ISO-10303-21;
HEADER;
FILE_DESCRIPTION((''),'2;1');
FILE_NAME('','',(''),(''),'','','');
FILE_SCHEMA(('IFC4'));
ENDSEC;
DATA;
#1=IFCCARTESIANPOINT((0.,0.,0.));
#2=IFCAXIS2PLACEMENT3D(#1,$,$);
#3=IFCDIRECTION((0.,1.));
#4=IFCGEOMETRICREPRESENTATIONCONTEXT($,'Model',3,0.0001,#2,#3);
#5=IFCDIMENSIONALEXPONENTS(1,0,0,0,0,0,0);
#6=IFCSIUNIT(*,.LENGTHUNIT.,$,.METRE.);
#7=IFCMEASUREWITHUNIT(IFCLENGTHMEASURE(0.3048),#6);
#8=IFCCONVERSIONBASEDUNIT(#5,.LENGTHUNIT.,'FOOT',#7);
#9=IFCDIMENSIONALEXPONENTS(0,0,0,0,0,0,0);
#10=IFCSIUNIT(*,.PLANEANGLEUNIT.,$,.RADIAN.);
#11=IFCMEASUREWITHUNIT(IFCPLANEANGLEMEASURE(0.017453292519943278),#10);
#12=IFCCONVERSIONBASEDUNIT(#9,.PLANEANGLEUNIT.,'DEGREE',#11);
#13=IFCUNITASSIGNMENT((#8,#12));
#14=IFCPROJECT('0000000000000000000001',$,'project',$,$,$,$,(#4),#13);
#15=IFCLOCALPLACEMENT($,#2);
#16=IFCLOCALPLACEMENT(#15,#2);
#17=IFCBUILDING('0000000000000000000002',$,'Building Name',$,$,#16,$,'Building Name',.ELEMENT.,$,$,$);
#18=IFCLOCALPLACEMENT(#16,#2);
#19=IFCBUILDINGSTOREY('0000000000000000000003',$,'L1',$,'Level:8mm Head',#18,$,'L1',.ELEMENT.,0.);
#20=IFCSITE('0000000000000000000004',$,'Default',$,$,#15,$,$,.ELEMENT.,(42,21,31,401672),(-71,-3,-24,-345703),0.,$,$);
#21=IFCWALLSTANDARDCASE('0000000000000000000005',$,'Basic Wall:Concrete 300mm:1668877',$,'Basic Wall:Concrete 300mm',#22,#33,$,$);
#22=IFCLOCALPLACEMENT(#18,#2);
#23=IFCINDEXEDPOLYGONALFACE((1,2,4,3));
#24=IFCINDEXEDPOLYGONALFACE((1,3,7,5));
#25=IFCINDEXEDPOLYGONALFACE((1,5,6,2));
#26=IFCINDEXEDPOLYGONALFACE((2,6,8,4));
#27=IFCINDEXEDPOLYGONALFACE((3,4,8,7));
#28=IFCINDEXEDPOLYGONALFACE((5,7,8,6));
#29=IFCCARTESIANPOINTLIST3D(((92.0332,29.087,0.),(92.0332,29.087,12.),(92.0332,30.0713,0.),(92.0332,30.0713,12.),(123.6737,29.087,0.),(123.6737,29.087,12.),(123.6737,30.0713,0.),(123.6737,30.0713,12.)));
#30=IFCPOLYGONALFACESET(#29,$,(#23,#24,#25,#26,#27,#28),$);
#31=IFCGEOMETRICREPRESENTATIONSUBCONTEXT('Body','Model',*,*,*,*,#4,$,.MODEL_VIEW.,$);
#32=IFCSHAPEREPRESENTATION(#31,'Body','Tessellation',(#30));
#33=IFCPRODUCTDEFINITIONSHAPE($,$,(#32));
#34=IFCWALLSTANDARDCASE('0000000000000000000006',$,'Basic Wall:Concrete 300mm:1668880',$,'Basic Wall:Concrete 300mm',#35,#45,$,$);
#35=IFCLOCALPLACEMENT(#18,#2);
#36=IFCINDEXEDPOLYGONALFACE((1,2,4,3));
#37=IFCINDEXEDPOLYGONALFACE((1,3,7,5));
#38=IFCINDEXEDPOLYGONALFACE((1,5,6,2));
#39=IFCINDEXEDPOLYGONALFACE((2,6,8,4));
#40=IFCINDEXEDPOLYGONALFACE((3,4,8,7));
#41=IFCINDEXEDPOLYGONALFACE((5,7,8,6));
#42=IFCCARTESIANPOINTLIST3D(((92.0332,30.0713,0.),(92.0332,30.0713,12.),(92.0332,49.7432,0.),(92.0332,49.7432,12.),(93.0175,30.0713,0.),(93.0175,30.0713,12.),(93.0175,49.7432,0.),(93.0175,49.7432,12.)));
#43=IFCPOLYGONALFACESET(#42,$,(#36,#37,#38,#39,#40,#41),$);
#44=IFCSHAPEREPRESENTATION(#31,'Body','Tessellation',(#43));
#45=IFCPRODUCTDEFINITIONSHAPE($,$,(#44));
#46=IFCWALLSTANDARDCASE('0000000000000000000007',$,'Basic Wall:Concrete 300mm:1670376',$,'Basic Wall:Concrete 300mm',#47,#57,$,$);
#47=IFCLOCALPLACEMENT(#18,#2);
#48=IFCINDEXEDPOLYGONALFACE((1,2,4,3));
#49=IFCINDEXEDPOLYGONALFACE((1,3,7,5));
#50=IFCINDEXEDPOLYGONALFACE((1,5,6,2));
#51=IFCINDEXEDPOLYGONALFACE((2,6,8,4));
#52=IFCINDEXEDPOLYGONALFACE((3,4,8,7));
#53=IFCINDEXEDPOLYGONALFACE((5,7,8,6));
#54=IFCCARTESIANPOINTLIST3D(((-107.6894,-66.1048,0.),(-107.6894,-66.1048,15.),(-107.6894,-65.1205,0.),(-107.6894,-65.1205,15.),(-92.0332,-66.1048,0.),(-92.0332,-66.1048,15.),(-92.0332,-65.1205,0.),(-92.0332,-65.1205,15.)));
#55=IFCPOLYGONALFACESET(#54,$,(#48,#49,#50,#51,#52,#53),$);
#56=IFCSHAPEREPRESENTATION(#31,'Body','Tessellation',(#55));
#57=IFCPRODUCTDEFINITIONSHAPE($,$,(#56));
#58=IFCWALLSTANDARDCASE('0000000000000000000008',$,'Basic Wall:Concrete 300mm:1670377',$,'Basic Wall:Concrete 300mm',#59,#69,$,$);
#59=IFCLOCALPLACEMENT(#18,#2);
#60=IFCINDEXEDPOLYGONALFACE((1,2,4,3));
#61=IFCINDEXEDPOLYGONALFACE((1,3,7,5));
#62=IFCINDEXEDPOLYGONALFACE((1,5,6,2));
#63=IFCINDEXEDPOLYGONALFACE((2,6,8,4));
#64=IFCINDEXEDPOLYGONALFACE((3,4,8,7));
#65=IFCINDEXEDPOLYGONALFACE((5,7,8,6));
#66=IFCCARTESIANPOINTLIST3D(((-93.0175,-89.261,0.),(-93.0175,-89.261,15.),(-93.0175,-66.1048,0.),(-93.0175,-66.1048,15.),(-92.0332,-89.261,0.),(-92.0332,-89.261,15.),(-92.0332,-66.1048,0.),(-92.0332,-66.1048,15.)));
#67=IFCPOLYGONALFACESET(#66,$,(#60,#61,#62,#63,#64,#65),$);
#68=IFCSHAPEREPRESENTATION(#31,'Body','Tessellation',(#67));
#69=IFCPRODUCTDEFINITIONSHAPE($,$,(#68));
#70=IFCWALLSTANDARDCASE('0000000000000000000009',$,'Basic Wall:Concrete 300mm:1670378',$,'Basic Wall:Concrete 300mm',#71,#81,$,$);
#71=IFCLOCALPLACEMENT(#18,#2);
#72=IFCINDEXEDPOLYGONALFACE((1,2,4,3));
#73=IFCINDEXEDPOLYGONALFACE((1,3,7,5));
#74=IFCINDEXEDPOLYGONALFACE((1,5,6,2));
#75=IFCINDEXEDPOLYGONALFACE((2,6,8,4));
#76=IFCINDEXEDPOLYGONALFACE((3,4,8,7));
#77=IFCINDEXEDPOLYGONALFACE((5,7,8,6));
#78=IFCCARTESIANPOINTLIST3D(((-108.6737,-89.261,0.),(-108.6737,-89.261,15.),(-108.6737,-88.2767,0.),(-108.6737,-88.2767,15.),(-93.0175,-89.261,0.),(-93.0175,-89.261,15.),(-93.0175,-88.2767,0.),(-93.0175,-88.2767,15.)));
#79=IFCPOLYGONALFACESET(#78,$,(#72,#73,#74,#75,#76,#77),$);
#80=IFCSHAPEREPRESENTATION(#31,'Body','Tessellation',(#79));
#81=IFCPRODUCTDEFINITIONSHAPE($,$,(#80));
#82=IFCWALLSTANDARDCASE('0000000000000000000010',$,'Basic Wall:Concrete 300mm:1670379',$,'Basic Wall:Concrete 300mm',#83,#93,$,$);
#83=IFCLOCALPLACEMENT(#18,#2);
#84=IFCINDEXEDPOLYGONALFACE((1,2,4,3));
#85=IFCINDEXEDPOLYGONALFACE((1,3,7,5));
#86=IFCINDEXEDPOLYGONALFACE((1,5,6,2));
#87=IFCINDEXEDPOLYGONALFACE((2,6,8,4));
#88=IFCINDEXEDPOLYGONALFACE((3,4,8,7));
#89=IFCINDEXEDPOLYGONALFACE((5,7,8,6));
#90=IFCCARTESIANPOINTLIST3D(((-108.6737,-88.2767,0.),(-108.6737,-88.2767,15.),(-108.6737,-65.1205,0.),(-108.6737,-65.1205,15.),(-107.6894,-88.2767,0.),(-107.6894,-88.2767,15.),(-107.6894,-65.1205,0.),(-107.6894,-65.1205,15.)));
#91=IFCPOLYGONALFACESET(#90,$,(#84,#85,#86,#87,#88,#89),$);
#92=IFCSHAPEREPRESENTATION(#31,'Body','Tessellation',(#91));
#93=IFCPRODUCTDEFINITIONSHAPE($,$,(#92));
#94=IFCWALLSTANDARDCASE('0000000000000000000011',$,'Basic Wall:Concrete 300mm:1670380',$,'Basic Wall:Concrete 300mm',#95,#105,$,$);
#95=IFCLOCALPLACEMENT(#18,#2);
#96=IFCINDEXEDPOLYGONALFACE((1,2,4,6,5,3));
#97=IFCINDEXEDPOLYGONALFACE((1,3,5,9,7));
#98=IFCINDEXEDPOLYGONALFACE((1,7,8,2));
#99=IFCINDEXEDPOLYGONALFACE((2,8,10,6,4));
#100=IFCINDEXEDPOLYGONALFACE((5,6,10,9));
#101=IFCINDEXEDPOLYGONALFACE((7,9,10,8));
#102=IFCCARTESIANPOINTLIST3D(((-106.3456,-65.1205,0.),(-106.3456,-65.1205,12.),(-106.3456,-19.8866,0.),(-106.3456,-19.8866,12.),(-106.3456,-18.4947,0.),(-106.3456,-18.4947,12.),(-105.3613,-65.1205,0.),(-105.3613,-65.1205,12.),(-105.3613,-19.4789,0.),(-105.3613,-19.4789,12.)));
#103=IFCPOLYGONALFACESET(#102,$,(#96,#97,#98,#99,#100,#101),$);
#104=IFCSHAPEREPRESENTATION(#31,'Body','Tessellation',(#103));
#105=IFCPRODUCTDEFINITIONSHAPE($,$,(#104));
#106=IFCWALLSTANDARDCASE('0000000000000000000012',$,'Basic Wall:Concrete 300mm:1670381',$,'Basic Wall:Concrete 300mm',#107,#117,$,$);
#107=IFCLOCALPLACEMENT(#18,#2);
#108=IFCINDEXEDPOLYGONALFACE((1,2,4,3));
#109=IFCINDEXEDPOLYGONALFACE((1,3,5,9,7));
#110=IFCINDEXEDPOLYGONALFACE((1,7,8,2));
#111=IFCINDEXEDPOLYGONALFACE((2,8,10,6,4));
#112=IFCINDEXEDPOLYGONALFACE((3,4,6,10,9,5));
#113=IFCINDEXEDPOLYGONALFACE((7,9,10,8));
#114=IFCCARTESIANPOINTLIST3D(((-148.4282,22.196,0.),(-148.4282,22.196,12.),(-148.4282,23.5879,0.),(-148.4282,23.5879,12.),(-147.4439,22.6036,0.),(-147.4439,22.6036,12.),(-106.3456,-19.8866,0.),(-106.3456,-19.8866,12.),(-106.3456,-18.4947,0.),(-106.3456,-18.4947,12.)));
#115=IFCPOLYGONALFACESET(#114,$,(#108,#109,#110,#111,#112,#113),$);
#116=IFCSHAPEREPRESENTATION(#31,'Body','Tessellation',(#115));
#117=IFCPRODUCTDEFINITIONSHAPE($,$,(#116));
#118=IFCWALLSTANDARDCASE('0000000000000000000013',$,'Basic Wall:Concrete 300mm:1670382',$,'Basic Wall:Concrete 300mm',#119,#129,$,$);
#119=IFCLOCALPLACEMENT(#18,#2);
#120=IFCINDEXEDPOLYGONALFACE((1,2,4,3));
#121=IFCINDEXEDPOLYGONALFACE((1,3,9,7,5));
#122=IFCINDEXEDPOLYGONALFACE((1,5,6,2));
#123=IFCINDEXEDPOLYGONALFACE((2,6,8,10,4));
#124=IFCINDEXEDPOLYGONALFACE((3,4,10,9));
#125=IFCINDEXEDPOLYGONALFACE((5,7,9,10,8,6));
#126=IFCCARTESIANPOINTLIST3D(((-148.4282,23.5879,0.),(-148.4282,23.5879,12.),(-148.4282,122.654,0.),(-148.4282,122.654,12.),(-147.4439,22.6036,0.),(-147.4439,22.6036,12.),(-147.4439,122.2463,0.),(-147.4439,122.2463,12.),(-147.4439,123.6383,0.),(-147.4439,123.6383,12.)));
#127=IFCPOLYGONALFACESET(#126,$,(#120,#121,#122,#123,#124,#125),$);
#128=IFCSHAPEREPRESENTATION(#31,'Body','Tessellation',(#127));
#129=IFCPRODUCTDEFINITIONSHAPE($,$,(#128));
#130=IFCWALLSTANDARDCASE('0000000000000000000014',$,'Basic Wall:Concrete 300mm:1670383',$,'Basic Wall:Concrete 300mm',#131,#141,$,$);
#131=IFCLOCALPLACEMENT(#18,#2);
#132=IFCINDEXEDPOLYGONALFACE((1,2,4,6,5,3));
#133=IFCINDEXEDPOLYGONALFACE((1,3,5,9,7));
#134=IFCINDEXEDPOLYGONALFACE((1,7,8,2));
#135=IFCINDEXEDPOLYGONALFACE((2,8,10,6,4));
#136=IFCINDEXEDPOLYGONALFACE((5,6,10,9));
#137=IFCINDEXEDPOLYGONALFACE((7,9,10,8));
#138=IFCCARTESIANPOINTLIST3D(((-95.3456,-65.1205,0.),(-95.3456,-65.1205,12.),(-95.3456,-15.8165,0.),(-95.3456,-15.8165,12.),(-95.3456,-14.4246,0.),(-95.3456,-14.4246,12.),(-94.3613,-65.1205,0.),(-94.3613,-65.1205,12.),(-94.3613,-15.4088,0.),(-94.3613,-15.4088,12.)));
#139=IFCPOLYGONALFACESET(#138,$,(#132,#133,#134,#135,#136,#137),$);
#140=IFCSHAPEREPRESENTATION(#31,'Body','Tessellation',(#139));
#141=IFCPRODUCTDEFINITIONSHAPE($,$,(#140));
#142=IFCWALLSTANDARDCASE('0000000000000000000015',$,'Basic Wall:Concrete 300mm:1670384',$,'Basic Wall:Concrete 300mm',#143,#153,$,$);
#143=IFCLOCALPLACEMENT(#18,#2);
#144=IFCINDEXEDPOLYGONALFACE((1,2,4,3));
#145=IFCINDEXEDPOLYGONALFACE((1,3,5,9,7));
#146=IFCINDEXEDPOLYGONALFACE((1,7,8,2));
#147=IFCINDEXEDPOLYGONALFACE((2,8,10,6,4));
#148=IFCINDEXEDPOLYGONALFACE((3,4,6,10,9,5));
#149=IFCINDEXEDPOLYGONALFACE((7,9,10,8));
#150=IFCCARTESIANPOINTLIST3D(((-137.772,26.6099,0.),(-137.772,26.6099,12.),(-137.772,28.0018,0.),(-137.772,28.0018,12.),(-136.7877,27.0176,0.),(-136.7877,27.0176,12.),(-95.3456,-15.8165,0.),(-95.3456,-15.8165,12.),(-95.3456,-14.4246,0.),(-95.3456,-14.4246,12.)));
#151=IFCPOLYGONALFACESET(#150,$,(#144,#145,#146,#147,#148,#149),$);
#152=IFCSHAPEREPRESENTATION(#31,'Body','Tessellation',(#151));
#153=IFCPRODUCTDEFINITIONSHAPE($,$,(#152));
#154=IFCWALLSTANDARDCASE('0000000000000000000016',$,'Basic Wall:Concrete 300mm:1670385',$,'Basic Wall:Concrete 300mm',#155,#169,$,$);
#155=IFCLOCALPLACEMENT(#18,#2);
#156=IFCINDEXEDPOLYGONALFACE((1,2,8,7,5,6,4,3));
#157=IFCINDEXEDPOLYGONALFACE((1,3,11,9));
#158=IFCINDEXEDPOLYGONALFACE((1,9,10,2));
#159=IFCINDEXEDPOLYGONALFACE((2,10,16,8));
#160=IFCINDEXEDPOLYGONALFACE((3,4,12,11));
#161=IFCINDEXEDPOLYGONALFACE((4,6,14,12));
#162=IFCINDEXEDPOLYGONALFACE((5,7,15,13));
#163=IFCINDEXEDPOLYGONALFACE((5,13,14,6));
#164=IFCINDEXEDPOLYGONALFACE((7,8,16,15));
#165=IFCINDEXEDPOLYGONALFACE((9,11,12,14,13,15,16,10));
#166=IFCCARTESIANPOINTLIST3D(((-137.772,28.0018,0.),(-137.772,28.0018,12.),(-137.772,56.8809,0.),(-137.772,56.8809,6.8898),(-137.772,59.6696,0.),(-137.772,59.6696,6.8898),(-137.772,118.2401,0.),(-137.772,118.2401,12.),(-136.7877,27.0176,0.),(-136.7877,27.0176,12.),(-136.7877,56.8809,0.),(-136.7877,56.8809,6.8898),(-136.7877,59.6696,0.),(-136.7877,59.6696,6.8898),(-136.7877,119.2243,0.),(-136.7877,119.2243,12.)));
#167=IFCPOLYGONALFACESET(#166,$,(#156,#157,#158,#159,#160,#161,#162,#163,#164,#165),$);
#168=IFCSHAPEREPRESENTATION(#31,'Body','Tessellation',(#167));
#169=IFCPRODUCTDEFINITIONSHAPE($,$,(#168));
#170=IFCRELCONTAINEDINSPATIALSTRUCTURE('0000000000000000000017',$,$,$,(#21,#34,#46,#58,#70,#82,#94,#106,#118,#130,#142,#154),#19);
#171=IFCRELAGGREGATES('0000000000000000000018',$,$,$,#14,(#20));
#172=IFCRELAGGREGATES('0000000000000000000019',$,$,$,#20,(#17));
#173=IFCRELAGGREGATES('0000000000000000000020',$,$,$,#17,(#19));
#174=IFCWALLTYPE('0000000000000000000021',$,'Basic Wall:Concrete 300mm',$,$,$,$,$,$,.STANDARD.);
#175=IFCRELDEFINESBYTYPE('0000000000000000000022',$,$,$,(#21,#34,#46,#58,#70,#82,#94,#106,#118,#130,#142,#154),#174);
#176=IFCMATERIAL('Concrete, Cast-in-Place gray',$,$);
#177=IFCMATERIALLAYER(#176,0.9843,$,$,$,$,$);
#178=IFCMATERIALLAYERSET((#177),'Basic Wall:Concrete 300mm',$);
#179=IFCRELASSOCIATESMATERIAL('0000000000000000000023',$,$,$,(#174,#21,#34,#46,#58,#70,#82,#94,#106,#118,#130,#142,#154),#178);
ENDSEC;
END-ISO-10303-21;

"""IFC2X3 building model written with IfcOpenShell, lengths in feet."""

from ifc_helpers import new_model, entity, si_unit, converted_unit, direction, frame, frame_2d, origin, place, context, subcontext, project, spatial, polyline, rectangle, outline, extrude, material, layer, layer_set, layer_usage, type_object, element, save


model = new_model("IFC2X3")

# Units and contexts
model_context = context("Model", 3, precision=0.0001, world=origin(), true_north=direction((0.0, 1.0)))
body_context = subcontext(model_context, "Body", "Model", "MODEL_VIEW")
ifc_project = project(units=[converted_unit("LENGTHUNIT", "FOOT", entity("IfcLengthMeasure", 0.3048), si_unit("LENGTHUNIT", "METRE"), dimensions=[1, 0, 0, 0, 0, 0, 0]), converted_unit("PLANEANGLEUNIT", "DEGREE", entity("IfcPlaneAngleMeasure", 0.017453292519943278), si_unit("PLANEANGLEUNIT", "RADIAN"), dimensions=[0, 0, 0, 0, 0, 0, 0])], contexts=[model_context])

# Site, building, storey
site_placement = place(None, origin())
site = spatial("IfcSite", under=ifc_project, at=site_placement, Name="Default", CompositionType="ELEMENT", RefLatitude=(42, 21, 31, 401672), RefLongitude=(-71, -3, -24, -345703), RefElevation=0.0)
building_placement = place(site_placement, origin())
building = spatial("IfcBuilding", under=site, at=building_placement, Name="Building Name", LongName="Building Name", CompositionType="ELEMENT")
storey_placement = place(building_placement, origin())
storey = spatial("IfcBuildingStorey", under=building, at=storey_placement, Name="L1", ObjectType="Level:8mm Head", LongName="L1", CompositionType="ELEMENT", Elevation=0.0)

# Shared definitions
ifc_material_1 = material(Name="Concrete, Cast-in-Place gray")
ifc_layer_1 = layer(ifc_material_1, 0.9843)
ifc_layer_set_1 = layer_set([ifc_layer_1], Name="Basic Wall:Concrete 300mm")
wall_type = type_object("IfcWallType", Name="Basic Wall:Concrete 300mm", PredefinedType="STANDARD", material=ifc_layer_set_1)

# Walls
ifc_layer_usage_1 = layer_usage(ifc_layer_set_1, "AXIS2", "NEGATIVE", 0.4921)
wall_1_placement = place(storey_placement, frame((123.6737, 29.5792, 0.0), z_axis=(0.0, 0.0, 1.0), x_axis=(-1.0, 0.0, 0.0)))
element("IfcWallStandardCase", 1, at=wall_1_placement, inside=storey, type_object=wall_type, material=ifc_layer_usage_1, Name="Basic Wall:Concrete 300mm:1668877", ObjectType="Basic Wall:Concrete 300mm", context=body_context, shape_type="SweptSolid", body=[
    extrude(rectangle(XDim=31.6404, YDim=0.9843, at=frame_2d((15.8202, 0.0), x_axis=(-1.0, 0.0))), origin(), (0.0, 0.0, 1.0), 12.0),
])
ifc_layer_usage_2 = layer_usage(ifc_layer_set_1, "AXIS2", "NEGATIVE", 0.4921)
wall_2_placement = place(storey_placement, frame((92.5254, 30.0713, 0.0), z_axis=(0.0, 0.0, 1.0), x_axis=(0.0, 1.0, 0.0)))
element("IfcWallStandardCase", 2, at=wall_2_placement, inside=storey, type_object=wall_type, material=ifc_layer_usage_2, Name="Basic Wall:Concrete 300mm:1668880", ObjectType="Basic Wall:Concrete 300mm", context=body_context, shape_type="SweptSolid", body=[
    extrude(rectangle(XDim=19.6719, YDim=0.9843, at=frame_2d((9.836, 0.0), x_axis=(-1.0, 0.0))), origin(), (0.0, 0.0, 1.0), 12.0),
])
ifc_layer_usage_3 = layer_usage(ifc_layer_set_1, "AXIS2", "POSITIVE", -0.4921)
wall_3_placement = place(storey_placement, frame((-92.0332, -65.6127, 0.0), z_axis=(0.0, 0.0, 1.0), x_axis=(-1.0, 0.0, 0.0)))
element("IfcWallStandardCase", 3, at=wall_3_placement, inside=storey, type_object=wall_type, material=ifc_layer_usage_3, Name="Basic Wall:Concrete 300mm:1670376", ObjectType="Basic Wall:Concrete 300mm", context=body_context, shape_type="SweptSolid", body=[
    extrude(rectangle(XDim=15.6562, YDim=0.9843, at=frame_2d((7.8281, 0.0), x_axis=(-1.0, 0.0))), origin(), (0.0, 0.0, 1.0), 15.0),
])
ifc_layer_usage_4 = layer_usage(ifc_layer_set_1, "AXIS2", "POSITIVE", -0.4921)
wall_4_placement = place(storey_placement, frame((-92.5254, -89.261, 0.0), z_axis=(0.0, 0.0, 1.0), x_axis=(0.0, 1.0, 0.0)))
element("IfcWallStandardCase", 4, at=wall_4_placement, inside=storey, type_object=wall_type, material=ifc_layer_usage_4, Name="Basic Wall:Concrete 300mm:1670377", ObjectType="Basic Wall:Concrete 300mm", context=body_context, shape_type="SweptSolid", body=[
    extrude(rectangle(XDim=23.1562, YDim=0.9843, at=frame_2d((11.5781, 0.0), x_axis=(-1.0, 0.0))), origin(), (0.0, 0.0, 1.0), 15.0),
])
ifc_layer_usage_5 = layer_usage(ifc_layer_set_1, "AXIS2", "NEGATIVE", 0.4921)
wall_5_placement = place(storey_placement, frame((-108.6737, -88.7688, 0.0)))
element("IfcWallStandardCase", 5, at=wall_5_placement, inside=storey, type_object=wall_type, material=ifc_layer_usage_5, Name="Basic Wall:Concrete 300mm:1670378", ObjectType="Basic Wall:Concrete 300mm", context=body_context, shape_type="SweptSolid", body=[
    extrude(rectangle(XDim=15.6562, YDim=0.9843, at=frame_2d((7.8281, 0.0), x_axis=(-1.0, 0.0))), origin(), (0.0, 0.0, 1.0), 15.0),
])
ifc_layer_usage_6 = layer_usage(ifc_layer_set_1, "AXIS2", "POSITIVE", -0.4921)
wall_6_placement = place(storey_placement, frame((-108.1815, -65.1205, 0.0), z_axis=(0.0, 0.0, 1.0), x_axis=(0.0, -1.0, 0.0)))
element("IfcWallStandardCase", 6, at=wall_6_placement, inside=storey, type_object=wall_type, material=ifc_layer_usage_6, Name="Basic Wall:Concrete 300mm:1670379", ObjectType="Basic Wall:Concrete 300mm", context=body_context, shape_type="SweptSolid", body=[
    extrude(rectangle(XDim=23.1562, YDim=0.9843, at=frame_2d((11.5781, 0.0), x_axis=(-1.0, 0.0))), origin(), (0.0, 0.0, 1.0), 15.0),
])
ifc_layer_usage_7 = layer_usage(ifc_layer_set_1, "AXIS2", "POSITIVE", -0.4921)
wall_7_placement = place(storey_placement, frame((-105.8535, -65.1205, 0.0), z_axis=(0.0, 0.0, 1.0), x_axis=(0.0, 1.0, 0.0)))
element("IfcWallStandardCase", 7, at=wall_7_placement, inside=storey, type_object=wall_type, material=ifc_layer_usage_7, Name="Basic Wall:Concrete 300mm:1670380", ObjectType="Basic Wall:Concrete 300mm", context=body_context, shape_type="SweptSolid", body=[
    extrude(outline(polyline([(45.6416, -0.4921), (46.6259, 0.4921), (45.2339, 0.4921), (0.0, 0.4921), (0.0, -0.4921), (45.6416, -0.4921)])), origin(), (0.0, 0.0, 1.0), 12.0),
])
ifc_layer_usage_8 = layer_usage(ifc_layer_set_1, "AXIS2", "POSITIVE", -0.4921)
wall_8_placement = place(storey_placement, frame((-105.9976, -19.5386, 0.0), z_axis=(0.0, 0.0, 1.0), x_axis=(-0.707107, 0.707107, 0.0)))
element("IfcWallStandardCase", 8, at=wall_8_placement, inside=storey, type_object=wall_type, material=ifc_layer_usage_8, Name="Basic Wall:Concrete 300mm:1670381", ObjectType="Basic Wall:Concrete 300mm", context=body_context, shape_type="SweptSolid", body=[
    extrude(outline(polyline([(60.498, -0.4921), (59.5137, 0.4921), (0.0, 0.4921), (0.9843, -0.4921), (59.1061, -0.4921), (60.498, -0.4921)])), origin(), (0.0, 0.0, 1.0), 12.0),
])
ifc_layer_usage_9 = layer_usage(ifc_layer_set_1, "AXIS2", "POSITIVE", -0.4921)
wall_9_placement = place(storey_placement, frame((-147.936, 22.6036, 0.0), z_axis=(0.0, 0.0, 1.0), x_axis=(0.0, 1.0, 0.0)))
element("IfcWallStandardCase", 9, at=wall_9_placement, inside=storey, type_object=wall_type, material=ifc_layer_usage_9, Name="Basic Wall:Concrete 300mm:1670382", ObjectType="Basic Wall:Concrete 300mm", context=body_context, shape_type="SweptSolid", body=[
    extrude(outline(polyline([(101.0346, -0.4921), (100.0504, 0.4921), (0.9843, 0.4921), (0.0, -0.4921), (99.6427, -0.4921), (101.0346, -0.4921)])), origin(), (0.0, 0.0, 1.0), 12.0),
])
ifc_layer_usage_10 = layer_usage(ifc_layer_set_1, "AXIS2", "POSITIVE", -0.4921)
wall_10_placement = place(storey_placement, frame((-94.8535, -65.1205, 0.0), z_axis=(0.0, 0.0, 1.0), x_axis=(0.0, 1.0, 0.0)))
element("IfcWallStandardCase", 10, at=wall_10_placement, inside=storey, type_object=wall_type, material=ifc_layer_usage_10, Name="Basic Wall:Concrete 300mm:1670383", ObjectType="Basic Wall:Concrete 300mm", context=body_context, shape_type="SweptSolid", body=[
    extrude(outline(polyline([(49.7117, -0.4921), (50.696, 0.4921), (49.304, 0.4921), (0.0, 0.4921), (0.0, -0.4921), (49.7117, -0.4921)])), origin(), (0.0, 0.0, 1.0), 12.0),
])
ifc_layer_usage_11 = layer_usage(ifc_layer_set_1, "AXIS2", "POSITIVE", -0.4921)
wall_11_placement = place(storey_placement, frame((-94.9976, -15.4685, 0.0), z_axis=(0.0, 0.0, 1.0), x_axis=(-0.707107, 0.707107, 0.0)))
element("IfcWallStandardCase", 11, at=wall_11_placement, inside=storey, type_object=wall_type, material=ifc_layer_usage_11, Name="Basic Wall:Concrete 300mm:1670384", ObjectType="Basic Wall:Concrete 300mm", context=body_context, shape_type="SweptSolid", body=[
    extrude(outline(polyline([(60.9843, -0.4921), (60.0, 0.4921), (0.0, 0.4921), (0.9843, -0.4921), (59.5923, -0.4921), (60.9843, -0.4921)])), origin(), (0.0, 0.0, 1.0), 12.0),
])

# Wall, opening
ifc_layer_usage_12 = layer_usage(ifc_layer_set_1, "AXIS2", "POSITIVE", -0.4921)
wall_12_placement = place(storey_placement, frame((-137.2799, 27.0176, 0.0), z_axis=(0.0, 0.0, 1.0), x_axis=(0.0, 1.0, 0.0)))
wall_12 = element("IfcWallStandardCase", 12, at=wall_12_placement, inside=storey, type_object=wall_type, material=ifc_layer_usage_12, Name="Basic Wall:Concrete 300mm:1670385", ObjectType="Basic Wall:Concrete 300mm", context=body_context, shape_type="SweptSolid", body=[
    extrude(outline(polyline([(0.0, -0.4921), (27.6015, -0.4921), (28.5858, -0.4921), (33.9296, -0.4921), (34.9139, -0.4921), (90.8148, -0.4921), (92.2068, -0.4921), (91.2225, 0.4921), (0.9843, 0.4921), (0.0, -0.4921)])), origin(), (0.0, 0.0, 1.0), 12.0),
])
opening_1_placement = place(wall_12_placement, frame((32.6521, 0.4921, 0.0)))
element("IfcOpeningElement", 13, at=opening_1_placement, cuts=wall_12, ObjectType="Opening", context=body_context, shape_type="SweptSolid", body=[
    extrude(rectangle(XDim=6.8898, YDim=2.7887, at=frame_2d((3.4449, 1.3944), x_axis=(1.0, 0.0))), frame((0.0, 0.0, 0.0), z_axis=(0.0, -1.0, 0.0), x_axis=(0.0, 0.0, 1.0)), (0.0, 0.0, 1.0), 0.9843),
])

save(model, "model.ifc")
